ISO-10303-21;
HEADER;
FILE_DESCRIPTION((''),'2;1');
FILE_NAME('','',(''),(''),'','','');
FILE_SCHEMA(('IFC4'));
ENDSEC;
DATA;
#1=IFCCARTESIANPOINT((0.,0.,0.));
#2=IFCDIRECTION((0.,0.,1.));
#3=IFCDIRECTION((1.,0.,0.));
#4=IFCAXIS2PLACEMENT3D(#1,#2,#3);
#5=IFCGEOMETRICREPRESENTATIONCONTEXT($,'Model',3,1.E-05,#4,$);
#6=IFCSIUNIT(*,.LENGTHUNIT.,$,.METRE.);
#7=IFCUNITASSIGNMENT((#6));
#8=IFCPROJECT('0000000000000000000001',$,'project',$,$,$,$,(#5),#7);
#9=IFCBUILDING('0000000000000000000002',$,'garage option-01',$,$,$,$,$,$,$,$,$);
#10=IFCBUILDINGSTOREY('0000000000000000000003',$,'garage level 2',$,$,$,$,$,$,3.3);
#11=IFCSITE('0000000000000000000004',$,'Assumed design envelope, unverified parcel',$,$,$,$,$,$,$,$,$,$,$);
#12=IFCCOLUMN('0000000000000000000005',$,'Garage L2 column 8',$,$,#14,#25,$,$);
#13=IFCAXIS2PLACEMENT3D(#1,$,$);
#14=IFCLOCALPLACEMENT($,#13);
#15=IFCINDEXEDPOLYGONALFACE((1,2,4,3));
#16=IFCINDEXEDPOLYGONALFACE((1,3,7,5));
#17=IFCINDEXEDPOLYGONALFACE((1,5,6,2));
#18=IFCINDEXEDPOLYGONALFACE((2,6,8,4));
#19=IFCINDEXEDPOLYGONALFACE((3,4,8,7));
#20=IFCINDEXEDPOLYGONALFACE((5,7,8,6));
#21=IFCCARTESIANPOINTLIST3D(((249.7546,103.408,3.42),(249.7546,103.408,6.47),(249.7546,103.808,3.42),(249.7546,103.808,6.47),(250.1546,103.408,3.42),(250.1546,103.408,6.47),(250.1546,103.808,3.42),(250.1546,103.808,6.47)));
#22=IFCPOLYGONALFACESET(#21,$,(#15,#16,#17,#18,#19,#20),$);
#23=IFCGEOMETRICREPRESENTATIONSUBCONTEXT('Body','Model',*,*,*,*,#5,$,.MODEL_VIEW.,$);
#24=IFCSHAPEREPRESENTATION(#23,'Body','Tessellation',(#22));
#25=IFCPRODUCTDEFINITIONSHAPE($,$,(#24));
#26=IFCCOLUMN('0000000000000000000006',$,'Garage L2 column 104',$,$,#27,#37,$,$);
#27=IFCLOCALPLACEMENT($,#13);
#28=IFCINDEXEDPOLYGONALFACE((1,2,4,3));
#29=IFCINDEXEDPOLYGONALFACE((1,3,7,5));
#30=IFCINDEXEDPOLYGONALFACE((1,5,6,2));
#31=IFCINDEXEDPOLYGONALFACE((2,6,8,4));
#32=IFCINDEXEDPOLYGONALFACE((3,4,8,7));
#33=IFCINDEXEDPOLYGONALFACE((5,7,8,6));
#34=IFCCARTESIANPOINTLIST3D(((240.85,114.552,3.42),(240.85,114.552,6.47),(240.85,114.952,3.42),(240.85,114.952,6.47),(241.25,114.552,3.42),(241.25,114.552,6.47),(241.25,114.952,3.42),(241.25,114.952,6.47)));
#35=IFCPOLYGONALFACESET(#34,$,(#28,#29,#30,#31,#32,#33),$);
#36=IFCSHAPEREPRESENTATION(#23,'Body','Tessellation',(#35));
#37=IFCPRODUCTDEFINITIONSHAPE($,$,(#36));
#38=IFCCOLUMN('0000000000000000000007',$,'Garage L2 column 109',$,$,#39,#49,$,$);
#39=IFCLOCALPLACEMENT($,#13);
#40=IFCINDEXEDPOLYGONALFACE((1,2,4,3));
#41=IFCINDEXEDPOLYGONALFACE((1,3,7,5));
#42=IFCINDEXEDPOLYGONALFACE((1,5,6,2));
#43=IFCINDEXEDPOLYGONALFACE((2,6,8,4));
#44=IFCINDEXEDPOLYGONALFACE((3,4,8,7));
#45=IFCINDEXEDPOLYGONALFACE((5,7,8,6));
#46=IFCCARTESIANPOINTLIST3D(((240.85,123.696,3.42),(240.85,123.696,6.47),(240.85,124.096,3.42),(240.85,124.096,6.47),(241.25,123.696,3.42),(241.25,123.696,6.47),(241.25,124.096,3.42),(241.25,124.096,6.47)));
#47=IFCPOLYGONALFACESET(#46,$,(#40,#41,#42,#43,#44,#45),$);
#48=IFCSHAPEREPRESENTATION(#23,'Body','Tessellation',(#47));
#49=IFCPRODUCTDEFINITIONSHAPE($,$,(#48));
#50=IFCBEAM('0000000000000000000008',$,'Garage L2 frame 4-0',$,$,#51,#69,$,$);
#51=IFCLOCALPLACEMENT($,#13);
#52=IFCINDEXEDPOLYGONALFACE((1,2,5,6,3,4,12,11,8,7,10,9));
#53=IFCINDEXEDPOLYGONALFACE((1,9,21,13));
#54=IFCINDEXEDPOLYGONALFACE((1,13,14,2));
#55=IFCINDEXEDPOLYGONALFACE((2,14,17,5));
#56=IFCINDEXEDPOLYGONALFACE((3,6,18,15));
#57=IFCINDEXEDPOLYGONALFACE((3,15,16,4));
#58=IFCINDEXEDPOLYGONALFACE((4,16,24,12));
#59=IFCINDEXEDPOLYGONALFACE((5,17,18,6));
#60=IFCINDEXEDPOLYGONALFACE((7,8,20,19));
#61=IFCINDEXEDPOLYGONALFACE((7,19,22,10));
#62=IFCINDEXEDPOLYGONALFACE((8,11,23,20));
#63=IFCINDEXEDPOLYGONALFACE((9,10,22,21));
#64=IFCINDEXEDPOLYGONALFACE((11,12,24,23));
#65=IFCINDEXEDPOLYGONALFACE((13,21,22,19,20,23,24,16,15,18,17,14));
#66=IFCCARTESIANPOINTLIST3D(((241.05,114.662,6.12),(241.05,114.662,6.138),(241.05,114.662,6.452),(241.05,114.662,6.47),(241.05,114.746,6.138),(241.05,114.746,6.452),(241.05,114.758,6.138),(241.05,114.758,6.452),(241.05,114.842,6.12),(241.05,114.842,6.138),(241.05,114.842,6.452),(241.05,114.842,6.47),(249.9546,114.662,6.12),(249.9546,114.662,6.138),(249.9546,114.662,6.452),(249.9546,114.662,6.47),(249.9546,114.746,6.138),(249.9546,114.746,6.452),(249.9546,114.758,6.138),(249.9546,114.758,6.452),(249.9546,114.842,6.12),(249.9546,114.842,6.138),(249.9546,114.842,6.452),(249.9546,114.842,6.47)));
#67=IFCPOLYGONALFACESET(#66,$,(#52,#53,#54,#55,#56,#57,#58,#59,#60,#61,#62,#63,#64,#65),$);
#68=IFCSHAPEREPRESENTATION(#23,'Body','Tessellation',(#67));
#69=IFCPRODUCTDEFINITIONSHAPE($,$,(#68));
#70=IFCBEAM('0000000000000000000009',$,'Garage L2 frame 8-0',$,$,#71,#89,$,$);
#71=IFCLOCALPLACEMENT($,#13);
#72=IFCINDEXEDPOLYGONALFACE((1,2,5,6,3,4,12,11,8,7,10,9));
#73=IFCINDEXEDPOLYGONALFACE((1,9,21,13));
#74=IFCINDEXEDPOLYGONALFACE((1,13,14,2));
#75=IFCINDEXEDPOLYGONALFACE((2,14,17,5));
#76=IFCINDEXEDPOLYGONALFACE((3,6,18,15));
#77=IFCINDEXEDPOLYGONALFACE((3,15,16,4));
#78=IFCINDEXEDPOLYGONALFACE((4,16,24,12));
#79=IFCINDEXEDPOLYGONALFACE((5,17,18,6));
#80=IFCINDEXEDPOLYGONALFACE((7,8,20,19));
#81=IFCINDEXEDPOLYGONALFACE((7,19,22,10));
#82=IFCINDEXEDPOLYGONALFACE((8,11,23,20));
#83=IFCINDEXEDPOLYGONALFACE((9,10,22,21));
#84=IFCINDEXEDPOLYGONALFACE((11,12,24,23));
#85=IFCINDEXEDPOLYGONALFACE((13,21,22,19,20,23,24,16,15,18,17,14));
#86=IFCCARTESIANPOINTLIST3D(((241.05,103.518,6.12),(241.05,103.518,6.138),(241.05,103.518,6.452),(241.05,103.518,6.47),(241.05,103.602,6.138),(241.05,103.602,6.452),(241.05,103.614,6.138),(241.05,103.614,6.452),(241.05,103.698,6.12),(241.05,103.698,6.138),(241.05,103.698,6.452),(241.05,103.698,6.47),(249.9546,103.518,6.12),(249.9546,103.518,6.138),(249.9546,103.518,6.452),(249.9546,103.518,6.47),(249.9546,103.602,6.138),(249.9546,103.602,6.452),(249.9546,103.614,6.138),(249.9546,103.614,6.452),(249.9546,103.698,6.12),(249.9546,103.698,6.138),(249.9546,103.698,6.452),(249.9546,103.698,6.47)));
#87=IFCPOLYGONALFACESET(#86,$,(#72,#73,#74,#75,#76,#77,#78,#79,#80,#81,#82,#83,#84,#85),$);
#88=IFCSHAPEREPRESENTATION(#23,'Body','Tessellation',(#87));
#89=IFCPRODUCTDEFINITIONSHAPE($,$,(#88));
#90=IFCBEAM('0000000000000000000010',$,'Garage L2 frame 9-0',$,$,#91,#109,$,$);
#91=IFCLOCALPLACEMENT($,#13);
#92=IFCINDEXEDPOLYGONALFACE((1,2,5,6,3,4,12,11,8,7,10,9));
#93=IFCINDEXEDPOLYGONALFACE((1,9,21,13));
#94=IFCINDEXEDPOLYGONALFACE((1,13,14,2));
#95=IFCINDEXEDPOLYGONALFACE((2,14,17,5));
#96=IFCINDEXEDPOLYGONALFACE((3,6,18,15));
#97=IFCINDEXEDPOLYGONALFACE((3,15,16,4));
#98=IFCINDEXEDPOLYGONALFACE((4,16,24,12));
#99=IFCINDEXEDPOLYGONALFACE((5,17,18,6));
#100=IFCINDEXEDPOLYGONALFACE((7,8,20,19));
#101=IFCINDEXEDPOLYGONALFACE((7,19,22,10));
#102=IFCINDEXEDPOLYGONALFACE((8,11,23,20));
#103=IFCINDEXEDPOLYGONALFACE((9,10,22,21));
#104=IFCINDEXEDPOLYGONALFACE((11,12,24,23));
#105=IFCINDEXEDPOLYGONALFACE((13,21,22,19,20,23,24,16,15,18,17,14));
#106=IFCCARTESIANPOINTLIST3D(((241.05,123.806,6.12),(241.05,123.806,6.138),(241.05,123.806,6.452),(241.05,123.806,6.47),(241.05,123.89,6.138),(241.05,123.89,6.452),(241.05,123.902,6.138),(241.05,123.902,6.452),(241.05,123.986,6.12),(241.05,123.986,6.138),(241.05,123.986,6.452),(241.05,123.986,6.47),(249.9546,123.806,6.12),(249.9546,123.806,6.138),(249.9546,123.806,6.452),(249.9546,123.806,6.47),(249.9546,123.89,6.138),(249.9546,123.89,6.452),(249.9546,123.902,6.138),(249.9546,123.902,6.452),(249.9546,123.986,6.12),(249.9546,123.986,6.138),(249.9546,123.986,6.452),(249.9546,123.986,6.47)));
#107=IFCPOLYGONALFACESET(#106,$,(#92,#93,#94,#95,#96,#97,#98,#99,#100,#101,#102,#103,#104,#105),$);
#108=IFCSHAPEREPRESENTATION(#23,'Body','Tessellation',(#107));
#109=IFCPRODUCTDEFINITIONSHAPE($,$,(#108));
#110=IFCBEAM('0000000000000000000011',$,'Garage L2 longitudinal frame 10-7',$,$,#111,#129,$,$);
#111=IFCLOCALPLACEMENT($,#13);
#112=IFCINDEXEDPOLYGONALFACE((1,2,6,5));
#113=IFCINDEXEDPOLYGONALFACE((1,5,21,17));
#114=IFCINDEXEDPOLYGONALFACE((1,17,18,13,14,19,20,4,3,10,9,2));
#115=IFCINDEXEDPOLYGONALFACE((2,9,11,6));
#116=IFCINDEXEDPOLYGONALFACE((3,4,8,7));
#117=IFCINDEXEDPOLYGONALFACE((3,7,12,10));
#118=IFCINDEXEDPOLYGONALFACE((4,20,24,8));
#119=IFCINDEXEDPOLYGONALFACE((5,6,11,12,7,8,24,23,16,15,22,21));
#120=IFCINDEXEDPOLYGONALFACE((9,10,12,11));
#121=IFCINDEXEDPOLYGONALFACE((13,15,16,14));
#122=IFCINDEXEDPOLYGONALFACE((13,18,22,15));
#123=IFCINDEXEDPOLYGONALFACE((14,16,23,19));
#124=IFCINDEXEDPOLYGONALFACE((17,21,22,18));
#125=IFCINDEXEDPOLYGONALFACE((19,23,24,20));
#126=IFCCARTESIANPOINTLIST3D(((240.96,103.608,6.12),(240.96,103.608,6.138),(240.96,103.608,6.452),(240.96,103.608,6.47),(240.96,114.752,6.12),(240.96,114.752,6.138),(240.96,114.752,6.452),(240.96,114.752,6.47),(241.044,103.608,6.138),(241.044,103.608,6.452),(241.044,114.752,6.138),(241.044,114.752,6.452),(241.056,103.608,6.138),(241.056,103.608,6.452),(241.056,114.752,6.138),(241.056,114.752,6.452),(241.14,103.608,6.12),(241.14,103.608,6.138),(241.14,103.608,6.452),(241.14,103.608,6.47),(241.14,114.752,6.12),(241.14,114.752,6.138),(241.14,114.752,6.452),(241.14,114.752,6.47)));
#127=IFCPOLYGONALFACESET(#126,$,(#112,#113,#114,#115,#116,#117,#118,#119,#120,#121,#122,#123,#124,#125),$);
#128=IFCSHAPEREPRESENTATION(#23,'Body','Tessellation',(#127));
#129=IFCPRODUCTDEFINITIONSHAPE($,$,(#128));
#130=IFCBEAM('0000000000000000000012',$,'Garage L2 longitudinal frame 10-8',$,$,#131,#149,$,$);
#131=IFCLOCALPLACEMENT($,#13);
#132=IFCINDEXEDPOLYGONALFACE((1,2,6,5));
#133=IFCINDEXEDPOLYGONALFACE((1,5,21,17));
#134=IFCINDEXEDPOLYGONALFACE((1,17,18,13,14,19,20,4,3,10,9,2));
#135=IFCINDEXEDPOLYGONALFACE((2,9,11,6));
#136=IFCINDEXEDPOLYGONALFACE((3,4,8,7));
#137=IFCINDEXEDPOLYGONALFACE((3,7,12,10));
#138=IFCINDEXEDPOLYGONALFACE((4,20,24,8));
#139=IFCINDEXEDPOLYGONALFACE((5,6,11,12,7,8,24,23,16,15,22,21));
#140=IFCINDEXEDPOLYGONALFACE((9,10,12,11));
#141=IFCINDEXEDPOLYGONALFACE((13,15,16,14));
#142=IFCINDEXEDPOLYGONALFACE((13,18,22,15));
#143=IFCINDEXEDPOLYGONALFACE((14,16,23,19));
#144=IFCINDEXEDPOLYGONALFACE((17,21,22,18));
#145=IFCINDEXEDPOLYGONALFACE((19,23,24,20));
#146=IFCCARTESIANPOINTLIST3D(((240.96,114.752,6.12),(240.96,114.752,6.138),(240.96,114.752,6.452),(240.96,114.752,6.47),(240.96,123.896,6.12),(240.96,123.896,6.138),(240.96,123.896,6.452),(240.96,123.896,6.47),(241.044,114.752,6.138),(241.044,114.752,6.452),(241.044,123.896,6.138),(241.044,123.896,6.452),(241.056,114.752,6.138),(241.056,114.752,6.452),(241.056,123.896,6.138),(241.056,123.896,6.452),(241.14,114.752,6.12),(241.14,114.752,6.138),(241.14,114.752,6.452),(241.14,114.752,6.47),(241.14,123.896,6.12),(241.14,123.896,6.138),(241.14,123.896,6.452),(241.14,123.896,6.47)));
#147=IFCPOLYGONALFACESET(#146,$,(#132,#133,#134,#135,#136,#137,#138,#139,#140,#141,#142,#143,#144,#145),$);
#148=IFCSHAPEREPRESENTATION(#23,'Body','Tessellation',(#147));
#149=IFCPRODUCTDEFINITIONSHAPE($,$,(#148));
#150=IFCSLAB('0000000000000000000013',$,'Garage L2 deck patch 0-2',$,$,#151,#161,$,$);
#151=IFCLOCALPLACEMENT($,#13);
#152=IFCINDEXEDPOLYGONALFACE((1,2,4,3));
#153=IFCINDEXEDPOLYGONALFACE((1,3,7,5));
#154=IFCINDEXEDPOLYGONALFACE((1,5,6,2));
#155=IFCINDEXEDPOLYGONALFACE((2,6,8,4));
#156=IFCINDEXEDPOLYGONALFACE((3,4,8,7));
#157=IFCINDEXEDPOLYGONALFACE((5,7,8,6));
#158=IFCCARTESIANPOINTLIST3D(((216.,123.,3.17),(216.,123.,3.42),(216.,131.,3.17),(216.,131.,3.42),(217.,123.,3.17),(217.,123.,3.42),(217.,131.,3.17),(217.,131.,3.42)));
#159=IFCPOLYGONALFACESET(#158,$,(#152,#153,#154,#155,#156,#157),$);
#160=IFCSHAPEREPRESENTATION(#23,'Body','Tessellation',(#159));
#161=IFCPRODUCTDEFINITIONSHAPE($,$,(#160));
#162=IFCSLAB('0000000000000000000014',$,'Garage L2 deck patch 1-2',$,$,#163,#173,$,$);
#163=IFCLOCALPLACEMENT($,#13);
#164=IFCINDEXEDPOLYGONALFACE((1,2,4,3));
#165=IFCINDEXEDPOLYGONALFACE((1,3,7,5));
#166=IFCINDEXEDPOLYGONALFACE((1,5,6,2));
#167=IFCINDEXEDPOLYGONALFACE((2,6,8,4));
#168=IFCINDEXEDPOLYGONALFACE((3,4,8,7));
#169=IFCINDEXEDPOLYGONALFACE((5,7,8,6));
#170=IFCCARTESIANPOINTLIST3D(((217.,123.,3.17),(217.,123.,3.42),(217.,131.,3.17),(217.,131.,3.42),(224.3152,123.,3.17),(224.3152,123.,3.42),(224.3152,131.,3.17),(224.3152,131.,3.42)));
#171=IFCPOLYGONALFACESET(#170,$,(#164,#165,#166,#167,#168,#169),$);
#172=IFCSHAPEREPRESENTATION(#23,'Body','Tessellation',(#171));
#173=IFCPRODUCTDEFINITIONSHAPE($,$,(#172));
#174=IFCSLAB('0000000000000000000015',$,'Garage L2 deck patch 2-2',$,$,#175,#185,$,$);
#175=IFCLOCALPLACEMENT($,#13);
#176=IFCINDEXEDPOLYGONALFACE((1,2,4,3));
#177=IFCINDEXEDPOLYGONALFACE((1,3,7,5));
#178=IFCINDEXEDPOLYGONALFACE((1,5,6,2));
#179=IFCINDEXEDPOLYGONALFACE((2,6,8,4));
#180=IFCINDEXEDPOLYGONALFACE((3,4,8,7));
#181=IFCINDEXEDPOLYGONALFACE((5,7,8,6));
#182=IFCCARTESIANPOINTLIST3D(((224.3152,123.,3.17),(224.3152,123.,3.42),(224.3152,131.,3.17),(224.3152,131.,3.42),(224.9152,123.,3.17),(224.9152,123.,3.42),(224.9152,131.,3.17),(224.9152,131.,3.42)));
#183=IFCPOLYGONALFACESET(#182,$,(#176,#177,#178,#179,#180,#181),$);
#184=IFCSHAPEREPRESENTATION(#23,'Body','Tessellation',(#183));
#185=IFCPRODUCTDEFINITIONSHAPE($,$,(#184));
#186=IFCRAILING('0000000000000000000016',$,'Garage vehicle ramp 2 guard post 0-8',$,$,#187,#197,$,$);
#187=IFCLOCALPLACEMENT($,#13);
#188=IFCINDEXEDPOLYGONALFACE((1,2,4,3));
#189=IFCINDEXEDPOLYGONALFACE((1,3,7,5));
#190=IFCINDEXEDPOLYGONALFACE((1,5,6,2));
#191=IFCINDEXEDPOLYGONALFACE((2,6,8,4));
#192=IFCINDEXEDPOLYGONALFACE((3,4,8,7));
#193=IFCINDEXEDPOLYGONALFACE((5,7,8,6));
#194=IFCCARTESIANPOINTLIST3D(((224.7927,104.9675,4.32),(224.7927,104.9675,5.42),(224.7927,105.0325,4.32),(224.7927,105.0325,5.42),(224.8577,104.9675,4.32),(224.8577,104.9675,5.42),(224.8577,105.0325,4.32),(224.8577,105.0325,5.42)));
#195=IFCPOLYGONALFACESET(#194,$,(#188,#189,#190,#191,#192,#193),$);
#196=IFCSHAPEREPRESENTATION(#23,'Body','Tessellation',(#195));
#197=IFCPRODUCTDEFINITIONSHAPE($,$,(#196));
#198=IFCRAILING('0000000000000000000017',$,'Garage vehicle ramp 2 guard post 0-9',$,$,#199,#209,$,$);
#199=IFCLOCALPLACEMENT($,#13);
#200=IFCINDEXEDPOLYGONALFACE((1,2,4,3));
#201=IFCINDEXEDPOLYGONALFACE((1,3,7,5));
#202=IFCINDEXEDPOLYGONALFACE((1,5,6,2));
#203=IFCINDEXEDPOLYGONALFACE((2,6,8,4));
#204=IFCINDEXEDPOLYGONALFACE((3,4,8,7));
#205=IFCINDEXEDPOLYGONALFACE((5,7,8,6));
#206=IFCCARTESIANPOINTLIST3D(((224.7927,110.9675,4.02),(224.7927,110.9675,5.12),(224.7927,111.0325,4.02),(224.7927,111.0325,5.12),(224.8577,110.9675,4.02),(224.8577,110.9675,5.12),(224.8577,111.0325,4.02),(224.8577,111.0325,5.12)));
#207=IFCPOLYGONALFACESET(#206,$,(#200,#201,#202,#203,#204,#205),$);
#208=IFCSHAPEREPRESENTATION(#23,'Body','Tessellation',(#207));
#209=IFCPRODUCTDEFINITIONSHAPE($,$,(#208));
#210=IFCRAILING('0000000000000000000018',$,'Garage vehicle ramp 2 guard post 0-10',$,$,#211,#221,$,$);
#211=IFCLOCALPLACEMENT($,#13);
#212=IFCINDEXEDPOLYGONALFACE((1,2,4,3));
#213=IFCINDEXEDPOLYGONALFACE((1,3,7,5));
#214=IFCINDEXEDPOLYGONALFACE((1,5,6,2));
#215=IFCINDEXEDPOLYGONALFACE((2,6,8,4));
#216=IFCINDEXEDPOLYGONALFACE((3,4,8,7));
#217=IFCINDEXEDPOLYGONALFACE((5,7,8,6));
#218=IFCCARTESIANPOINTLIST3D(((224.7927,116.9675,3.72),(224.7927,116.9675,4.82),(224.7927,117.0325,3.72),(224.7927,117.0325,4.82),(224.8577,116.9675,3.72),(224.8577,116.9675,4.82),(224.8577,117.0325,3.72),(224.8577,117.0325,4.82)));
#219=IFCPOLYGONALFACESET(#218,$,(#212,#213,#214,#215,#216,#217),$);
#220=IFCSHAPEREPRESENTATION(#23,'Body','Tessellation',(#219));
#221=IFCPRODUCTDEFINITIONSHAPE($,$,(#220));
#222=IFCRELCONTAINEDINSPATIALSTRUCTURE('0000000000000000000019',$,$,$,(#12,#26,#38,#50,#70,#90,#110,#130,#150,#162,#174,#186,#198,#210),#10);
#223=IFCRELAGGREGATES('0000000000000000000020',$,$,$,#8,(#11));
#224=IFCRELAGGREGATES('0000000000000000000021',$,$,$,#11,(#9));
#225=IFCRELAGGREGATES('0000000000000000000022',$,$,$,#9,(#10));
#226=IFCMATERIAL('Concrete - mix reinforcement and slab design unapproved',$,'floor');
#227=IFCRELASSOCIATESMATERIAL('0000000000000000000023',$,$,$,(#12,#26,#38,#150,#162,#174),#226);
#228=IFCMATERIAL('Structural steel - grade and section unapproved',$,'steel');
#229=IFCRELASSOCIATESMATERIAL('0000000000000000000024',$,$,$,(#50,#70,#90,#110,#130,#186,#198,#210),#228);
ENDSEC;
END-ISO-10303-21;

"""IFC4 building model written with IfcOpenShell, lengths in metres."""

from ifc_helpers import new_model, si_unit, frame, origin_with_axes, place, context, subcontext, project, spatial, rectangle, i_section, extrude, material, element, save


model = new_model("IFC4")

# Units and contexts
model_context = context("Model", 3, precision=1e-05, world=origin_with_axes())
body_context = subcontext(model_context, "Body", "Model", "MODEL_VIEW")
ifc_project = project(units=[si_unit("LENGTHUNIT", "METRE")], contexts=[model_context])

# Site, building, storey
site = spatial("IfcSite", under=ifc_project, Name="Assumed design envelope, unverified parcel")
building = spatial("IfcBuilding", under=site, Name="garage option-01")
storey = spatial("IfcBuildingStorey", under=building, Name="garage level 2", Elevation=3.3)

# Columns
ifc_material_1 = material(Name="Concrete - mix reinforcement and slab design unapproved", Category="floor")
for number, where, z_axis, x_axis, name in (
    (1, (249.9546, 103.608, 3.42), (0.0, 0.0, 1.0), (1.0, 0.0, 0.0), "Garage L2 column 8"),
    (2, (241.05, 114.752, 3.42), (0.0, 0.0, 1.0), (1.0, 0.0, 0.0), "Garage L2 column 104"),
    (3, (241.05, 123.896, 3.42), (0.0, 0.0, 1.0), (1.0, 0.0, 0.0), "Garage L2 column 109"),
):
    element("IfcColumn", number, at=place(None, frame(where, z_axis=z_axis, x_axis=x_axis)), inside=storey, material=ifc_material_1, Name=name, context=body_context, shape_type="SweptSolid", body=[
        extrude(rectangle(XDim=0.4, YDim=0.4), origin_with_axes(), (0.0, 0.0, 1.0), 3.05),
    ])

# Beams
ifc_material_2 = material(Name="Structural steel - grade and section unapproved", Category="steel")
for number, where, z_axis, x_axis, name in (
    (4, (241.05, 114.752, 6.295), (1.0, 0.0, 0.0), (0.0, 1.0, 0.0), "Garage L2 frame 4-0"),
    (5, (241.05, 103.608, 6.295), (1.0, 0.0, 0.0), (0.0, 1.0, 0.0), "Garage L2 frame 8-0"),
    (6, (241.05, 123.896, 6.295), (1.0, 0.0, 0.0), (0.0, 1.0, 0.0), "Garage L2 frame 9-0"),
):
    element("IfcBeam", number, at=place(None, frame(where, z_axis=z_axis, x_axis=x_axis)), inside=storey, material=ifc_material_2, Name=name, context=body_context, shape_type="SweptSolid", body=[
        extrude(i_section(OverallWidth=0.18, OverallDepth=0.35, WebThickness=0.012, FlangeThickness=0.018, FilletRadius=0.0), origin_with_axes(), (0.0, 0.0, 1.0), 8.9046),
    ])
beam_1_placement = place(None, frame((241.05, 103.608, 6.295), z_axis=(0.0, 1.0, 0.0), x_axis=(-1.0, 0.0, 0.0)))
element("IfcBeam", 7, at=beam_1_placement, inside=storey, material=ifc_material_2, Name="Garage L2 longitudinal frame 10-7", context=body_context, shape_type="SweptSolid", body=[
    extrude(i_section(OverallWidth=0.18, OverallDepth=0.35, WebThickness=0.012, FlangeThickness=0.018, FilletRadius=0.0), origin_with_axes(), (0.0, 0.0, 1.0), 11.144),
])
beam_2_placement = place(None, frame((241.05, 114.752, 6.295), z_axis=(0.0, 1.0, 0.0), x_axis=(-1.0, 0.0, 0.0)))
element("IfcBeam", 8, at=beam_2_placement, inside=storey, material=ifc_material_2, Name="Garage L2 longitudinal frame 10-8", context=body_context, shape_type="SweptSolid", body=[
    extrude(i_section(OverallWidth=0.18, OverallDepth=0.35, WebThickness=0.012, FlangeThickness=0.018, FilletRadius=0.0), origin_with_axes(), (0.0, 0.0, 1.0), 9.144),
])

# Slabs
slab_1_placement = place(None, frame((216.5, 127.0, 3.17), z_axis=(0.0, 0.0, 1.0), x_axis=(1.0, 0.0, 0.0)))
element("IfcSlab", 9, at=slab_1_placement, inside=storey, material=ifc_material_1, Name="Garage L2 deck patch 0-2", context=body_context, shape_type="SweptSolid", body=[
    extrude(rectangle(XDim=1.0, YDim=8.0), origin_with_axes(), (0.0, 0.0, 1.0), 0.25),
])
slab_2_placement = place(None, frame((220.6576, 127.0, 3.17), z_axis=(0.0, 0.0, 1.0), x_axis=(1.0, 0.0, 0.0)))
element("IfcSlab", 10, at=slab_2_placement, inside=storey, material=ifc_material_1, Name="Garage L2 deck patch 1-2", context=body_context, shape_type="SweptSolid", body=[
    extrude(rectangle(XDim=7.3152, YDim=8.0), origin_with_axes(), (0.0, 0.0, 1.0), 0.25),
])
slab_3_placement = place(None, frame((224.6152, 127.0, 3.17), z_axis=(0.0, 0.0, 1.0), x_axis=(1.0, 0.0, 0.0)))
element("IfcSlab", 11, at=slab_3_placement, inside=storey, material=ifc_material_1, Name="Garage L2 deck patch 2-2", context=body_context, shape_type="SweptSolid", body=[
    extrude(rectangle(XDim=0.6, YDim=8.0), origin_with_axes(), (0.0, 0.0, 1.0), 0.25),
])

# Railings
for number, where, z_axis, x_axis, name in (
    (12, (224.8252, 105.0, 4.32), (0.0, 0.0, 1.0), (-1.0, 0.0, 0.0), "Garage vehicle ramp 2 guard post 0-8"),
    (13, (224.8252, 111.0, 4.02), (0.0, 0.0, 1.0), (-1.0, 0.0, 0.0), "Garage vehicle ramp 2 guard post 0-9"),
):
    element("IfcRailing", number, at=place(None, frame(where, z_axis=z_axis, x_axis=x_axis)), inside=storey, material=ifc_material_2, Name=name, context=body_context, shape_type="SweptSolid", body=[
        extrude(rectangle(XDim=0.065, YDim=0.065), origin_with_axes(), (0.0, 0.0, 1.0), 1.1),
    ])
railing_1_placement = place(None, frame((224.8252, 117.0, 3.72), z_axis=(0.0, 0.0, 1.0), x_axis=(-1.0, 0.0, 0.0)))
element("IfcRailing", 14, at=railing_1_placement, inside=storey, material=ifc_material_2, Name="Garage vehicle ramp 2 guard post 0-10", context=body_context, shape_type="SweptSolid", body=[
    extrude(rectangle(XDim=0.065, YDim=0.065), origin_with_axes(), (0.0, 0.0, 1.0), 1.1),
])

save(model, "model.ifc")
